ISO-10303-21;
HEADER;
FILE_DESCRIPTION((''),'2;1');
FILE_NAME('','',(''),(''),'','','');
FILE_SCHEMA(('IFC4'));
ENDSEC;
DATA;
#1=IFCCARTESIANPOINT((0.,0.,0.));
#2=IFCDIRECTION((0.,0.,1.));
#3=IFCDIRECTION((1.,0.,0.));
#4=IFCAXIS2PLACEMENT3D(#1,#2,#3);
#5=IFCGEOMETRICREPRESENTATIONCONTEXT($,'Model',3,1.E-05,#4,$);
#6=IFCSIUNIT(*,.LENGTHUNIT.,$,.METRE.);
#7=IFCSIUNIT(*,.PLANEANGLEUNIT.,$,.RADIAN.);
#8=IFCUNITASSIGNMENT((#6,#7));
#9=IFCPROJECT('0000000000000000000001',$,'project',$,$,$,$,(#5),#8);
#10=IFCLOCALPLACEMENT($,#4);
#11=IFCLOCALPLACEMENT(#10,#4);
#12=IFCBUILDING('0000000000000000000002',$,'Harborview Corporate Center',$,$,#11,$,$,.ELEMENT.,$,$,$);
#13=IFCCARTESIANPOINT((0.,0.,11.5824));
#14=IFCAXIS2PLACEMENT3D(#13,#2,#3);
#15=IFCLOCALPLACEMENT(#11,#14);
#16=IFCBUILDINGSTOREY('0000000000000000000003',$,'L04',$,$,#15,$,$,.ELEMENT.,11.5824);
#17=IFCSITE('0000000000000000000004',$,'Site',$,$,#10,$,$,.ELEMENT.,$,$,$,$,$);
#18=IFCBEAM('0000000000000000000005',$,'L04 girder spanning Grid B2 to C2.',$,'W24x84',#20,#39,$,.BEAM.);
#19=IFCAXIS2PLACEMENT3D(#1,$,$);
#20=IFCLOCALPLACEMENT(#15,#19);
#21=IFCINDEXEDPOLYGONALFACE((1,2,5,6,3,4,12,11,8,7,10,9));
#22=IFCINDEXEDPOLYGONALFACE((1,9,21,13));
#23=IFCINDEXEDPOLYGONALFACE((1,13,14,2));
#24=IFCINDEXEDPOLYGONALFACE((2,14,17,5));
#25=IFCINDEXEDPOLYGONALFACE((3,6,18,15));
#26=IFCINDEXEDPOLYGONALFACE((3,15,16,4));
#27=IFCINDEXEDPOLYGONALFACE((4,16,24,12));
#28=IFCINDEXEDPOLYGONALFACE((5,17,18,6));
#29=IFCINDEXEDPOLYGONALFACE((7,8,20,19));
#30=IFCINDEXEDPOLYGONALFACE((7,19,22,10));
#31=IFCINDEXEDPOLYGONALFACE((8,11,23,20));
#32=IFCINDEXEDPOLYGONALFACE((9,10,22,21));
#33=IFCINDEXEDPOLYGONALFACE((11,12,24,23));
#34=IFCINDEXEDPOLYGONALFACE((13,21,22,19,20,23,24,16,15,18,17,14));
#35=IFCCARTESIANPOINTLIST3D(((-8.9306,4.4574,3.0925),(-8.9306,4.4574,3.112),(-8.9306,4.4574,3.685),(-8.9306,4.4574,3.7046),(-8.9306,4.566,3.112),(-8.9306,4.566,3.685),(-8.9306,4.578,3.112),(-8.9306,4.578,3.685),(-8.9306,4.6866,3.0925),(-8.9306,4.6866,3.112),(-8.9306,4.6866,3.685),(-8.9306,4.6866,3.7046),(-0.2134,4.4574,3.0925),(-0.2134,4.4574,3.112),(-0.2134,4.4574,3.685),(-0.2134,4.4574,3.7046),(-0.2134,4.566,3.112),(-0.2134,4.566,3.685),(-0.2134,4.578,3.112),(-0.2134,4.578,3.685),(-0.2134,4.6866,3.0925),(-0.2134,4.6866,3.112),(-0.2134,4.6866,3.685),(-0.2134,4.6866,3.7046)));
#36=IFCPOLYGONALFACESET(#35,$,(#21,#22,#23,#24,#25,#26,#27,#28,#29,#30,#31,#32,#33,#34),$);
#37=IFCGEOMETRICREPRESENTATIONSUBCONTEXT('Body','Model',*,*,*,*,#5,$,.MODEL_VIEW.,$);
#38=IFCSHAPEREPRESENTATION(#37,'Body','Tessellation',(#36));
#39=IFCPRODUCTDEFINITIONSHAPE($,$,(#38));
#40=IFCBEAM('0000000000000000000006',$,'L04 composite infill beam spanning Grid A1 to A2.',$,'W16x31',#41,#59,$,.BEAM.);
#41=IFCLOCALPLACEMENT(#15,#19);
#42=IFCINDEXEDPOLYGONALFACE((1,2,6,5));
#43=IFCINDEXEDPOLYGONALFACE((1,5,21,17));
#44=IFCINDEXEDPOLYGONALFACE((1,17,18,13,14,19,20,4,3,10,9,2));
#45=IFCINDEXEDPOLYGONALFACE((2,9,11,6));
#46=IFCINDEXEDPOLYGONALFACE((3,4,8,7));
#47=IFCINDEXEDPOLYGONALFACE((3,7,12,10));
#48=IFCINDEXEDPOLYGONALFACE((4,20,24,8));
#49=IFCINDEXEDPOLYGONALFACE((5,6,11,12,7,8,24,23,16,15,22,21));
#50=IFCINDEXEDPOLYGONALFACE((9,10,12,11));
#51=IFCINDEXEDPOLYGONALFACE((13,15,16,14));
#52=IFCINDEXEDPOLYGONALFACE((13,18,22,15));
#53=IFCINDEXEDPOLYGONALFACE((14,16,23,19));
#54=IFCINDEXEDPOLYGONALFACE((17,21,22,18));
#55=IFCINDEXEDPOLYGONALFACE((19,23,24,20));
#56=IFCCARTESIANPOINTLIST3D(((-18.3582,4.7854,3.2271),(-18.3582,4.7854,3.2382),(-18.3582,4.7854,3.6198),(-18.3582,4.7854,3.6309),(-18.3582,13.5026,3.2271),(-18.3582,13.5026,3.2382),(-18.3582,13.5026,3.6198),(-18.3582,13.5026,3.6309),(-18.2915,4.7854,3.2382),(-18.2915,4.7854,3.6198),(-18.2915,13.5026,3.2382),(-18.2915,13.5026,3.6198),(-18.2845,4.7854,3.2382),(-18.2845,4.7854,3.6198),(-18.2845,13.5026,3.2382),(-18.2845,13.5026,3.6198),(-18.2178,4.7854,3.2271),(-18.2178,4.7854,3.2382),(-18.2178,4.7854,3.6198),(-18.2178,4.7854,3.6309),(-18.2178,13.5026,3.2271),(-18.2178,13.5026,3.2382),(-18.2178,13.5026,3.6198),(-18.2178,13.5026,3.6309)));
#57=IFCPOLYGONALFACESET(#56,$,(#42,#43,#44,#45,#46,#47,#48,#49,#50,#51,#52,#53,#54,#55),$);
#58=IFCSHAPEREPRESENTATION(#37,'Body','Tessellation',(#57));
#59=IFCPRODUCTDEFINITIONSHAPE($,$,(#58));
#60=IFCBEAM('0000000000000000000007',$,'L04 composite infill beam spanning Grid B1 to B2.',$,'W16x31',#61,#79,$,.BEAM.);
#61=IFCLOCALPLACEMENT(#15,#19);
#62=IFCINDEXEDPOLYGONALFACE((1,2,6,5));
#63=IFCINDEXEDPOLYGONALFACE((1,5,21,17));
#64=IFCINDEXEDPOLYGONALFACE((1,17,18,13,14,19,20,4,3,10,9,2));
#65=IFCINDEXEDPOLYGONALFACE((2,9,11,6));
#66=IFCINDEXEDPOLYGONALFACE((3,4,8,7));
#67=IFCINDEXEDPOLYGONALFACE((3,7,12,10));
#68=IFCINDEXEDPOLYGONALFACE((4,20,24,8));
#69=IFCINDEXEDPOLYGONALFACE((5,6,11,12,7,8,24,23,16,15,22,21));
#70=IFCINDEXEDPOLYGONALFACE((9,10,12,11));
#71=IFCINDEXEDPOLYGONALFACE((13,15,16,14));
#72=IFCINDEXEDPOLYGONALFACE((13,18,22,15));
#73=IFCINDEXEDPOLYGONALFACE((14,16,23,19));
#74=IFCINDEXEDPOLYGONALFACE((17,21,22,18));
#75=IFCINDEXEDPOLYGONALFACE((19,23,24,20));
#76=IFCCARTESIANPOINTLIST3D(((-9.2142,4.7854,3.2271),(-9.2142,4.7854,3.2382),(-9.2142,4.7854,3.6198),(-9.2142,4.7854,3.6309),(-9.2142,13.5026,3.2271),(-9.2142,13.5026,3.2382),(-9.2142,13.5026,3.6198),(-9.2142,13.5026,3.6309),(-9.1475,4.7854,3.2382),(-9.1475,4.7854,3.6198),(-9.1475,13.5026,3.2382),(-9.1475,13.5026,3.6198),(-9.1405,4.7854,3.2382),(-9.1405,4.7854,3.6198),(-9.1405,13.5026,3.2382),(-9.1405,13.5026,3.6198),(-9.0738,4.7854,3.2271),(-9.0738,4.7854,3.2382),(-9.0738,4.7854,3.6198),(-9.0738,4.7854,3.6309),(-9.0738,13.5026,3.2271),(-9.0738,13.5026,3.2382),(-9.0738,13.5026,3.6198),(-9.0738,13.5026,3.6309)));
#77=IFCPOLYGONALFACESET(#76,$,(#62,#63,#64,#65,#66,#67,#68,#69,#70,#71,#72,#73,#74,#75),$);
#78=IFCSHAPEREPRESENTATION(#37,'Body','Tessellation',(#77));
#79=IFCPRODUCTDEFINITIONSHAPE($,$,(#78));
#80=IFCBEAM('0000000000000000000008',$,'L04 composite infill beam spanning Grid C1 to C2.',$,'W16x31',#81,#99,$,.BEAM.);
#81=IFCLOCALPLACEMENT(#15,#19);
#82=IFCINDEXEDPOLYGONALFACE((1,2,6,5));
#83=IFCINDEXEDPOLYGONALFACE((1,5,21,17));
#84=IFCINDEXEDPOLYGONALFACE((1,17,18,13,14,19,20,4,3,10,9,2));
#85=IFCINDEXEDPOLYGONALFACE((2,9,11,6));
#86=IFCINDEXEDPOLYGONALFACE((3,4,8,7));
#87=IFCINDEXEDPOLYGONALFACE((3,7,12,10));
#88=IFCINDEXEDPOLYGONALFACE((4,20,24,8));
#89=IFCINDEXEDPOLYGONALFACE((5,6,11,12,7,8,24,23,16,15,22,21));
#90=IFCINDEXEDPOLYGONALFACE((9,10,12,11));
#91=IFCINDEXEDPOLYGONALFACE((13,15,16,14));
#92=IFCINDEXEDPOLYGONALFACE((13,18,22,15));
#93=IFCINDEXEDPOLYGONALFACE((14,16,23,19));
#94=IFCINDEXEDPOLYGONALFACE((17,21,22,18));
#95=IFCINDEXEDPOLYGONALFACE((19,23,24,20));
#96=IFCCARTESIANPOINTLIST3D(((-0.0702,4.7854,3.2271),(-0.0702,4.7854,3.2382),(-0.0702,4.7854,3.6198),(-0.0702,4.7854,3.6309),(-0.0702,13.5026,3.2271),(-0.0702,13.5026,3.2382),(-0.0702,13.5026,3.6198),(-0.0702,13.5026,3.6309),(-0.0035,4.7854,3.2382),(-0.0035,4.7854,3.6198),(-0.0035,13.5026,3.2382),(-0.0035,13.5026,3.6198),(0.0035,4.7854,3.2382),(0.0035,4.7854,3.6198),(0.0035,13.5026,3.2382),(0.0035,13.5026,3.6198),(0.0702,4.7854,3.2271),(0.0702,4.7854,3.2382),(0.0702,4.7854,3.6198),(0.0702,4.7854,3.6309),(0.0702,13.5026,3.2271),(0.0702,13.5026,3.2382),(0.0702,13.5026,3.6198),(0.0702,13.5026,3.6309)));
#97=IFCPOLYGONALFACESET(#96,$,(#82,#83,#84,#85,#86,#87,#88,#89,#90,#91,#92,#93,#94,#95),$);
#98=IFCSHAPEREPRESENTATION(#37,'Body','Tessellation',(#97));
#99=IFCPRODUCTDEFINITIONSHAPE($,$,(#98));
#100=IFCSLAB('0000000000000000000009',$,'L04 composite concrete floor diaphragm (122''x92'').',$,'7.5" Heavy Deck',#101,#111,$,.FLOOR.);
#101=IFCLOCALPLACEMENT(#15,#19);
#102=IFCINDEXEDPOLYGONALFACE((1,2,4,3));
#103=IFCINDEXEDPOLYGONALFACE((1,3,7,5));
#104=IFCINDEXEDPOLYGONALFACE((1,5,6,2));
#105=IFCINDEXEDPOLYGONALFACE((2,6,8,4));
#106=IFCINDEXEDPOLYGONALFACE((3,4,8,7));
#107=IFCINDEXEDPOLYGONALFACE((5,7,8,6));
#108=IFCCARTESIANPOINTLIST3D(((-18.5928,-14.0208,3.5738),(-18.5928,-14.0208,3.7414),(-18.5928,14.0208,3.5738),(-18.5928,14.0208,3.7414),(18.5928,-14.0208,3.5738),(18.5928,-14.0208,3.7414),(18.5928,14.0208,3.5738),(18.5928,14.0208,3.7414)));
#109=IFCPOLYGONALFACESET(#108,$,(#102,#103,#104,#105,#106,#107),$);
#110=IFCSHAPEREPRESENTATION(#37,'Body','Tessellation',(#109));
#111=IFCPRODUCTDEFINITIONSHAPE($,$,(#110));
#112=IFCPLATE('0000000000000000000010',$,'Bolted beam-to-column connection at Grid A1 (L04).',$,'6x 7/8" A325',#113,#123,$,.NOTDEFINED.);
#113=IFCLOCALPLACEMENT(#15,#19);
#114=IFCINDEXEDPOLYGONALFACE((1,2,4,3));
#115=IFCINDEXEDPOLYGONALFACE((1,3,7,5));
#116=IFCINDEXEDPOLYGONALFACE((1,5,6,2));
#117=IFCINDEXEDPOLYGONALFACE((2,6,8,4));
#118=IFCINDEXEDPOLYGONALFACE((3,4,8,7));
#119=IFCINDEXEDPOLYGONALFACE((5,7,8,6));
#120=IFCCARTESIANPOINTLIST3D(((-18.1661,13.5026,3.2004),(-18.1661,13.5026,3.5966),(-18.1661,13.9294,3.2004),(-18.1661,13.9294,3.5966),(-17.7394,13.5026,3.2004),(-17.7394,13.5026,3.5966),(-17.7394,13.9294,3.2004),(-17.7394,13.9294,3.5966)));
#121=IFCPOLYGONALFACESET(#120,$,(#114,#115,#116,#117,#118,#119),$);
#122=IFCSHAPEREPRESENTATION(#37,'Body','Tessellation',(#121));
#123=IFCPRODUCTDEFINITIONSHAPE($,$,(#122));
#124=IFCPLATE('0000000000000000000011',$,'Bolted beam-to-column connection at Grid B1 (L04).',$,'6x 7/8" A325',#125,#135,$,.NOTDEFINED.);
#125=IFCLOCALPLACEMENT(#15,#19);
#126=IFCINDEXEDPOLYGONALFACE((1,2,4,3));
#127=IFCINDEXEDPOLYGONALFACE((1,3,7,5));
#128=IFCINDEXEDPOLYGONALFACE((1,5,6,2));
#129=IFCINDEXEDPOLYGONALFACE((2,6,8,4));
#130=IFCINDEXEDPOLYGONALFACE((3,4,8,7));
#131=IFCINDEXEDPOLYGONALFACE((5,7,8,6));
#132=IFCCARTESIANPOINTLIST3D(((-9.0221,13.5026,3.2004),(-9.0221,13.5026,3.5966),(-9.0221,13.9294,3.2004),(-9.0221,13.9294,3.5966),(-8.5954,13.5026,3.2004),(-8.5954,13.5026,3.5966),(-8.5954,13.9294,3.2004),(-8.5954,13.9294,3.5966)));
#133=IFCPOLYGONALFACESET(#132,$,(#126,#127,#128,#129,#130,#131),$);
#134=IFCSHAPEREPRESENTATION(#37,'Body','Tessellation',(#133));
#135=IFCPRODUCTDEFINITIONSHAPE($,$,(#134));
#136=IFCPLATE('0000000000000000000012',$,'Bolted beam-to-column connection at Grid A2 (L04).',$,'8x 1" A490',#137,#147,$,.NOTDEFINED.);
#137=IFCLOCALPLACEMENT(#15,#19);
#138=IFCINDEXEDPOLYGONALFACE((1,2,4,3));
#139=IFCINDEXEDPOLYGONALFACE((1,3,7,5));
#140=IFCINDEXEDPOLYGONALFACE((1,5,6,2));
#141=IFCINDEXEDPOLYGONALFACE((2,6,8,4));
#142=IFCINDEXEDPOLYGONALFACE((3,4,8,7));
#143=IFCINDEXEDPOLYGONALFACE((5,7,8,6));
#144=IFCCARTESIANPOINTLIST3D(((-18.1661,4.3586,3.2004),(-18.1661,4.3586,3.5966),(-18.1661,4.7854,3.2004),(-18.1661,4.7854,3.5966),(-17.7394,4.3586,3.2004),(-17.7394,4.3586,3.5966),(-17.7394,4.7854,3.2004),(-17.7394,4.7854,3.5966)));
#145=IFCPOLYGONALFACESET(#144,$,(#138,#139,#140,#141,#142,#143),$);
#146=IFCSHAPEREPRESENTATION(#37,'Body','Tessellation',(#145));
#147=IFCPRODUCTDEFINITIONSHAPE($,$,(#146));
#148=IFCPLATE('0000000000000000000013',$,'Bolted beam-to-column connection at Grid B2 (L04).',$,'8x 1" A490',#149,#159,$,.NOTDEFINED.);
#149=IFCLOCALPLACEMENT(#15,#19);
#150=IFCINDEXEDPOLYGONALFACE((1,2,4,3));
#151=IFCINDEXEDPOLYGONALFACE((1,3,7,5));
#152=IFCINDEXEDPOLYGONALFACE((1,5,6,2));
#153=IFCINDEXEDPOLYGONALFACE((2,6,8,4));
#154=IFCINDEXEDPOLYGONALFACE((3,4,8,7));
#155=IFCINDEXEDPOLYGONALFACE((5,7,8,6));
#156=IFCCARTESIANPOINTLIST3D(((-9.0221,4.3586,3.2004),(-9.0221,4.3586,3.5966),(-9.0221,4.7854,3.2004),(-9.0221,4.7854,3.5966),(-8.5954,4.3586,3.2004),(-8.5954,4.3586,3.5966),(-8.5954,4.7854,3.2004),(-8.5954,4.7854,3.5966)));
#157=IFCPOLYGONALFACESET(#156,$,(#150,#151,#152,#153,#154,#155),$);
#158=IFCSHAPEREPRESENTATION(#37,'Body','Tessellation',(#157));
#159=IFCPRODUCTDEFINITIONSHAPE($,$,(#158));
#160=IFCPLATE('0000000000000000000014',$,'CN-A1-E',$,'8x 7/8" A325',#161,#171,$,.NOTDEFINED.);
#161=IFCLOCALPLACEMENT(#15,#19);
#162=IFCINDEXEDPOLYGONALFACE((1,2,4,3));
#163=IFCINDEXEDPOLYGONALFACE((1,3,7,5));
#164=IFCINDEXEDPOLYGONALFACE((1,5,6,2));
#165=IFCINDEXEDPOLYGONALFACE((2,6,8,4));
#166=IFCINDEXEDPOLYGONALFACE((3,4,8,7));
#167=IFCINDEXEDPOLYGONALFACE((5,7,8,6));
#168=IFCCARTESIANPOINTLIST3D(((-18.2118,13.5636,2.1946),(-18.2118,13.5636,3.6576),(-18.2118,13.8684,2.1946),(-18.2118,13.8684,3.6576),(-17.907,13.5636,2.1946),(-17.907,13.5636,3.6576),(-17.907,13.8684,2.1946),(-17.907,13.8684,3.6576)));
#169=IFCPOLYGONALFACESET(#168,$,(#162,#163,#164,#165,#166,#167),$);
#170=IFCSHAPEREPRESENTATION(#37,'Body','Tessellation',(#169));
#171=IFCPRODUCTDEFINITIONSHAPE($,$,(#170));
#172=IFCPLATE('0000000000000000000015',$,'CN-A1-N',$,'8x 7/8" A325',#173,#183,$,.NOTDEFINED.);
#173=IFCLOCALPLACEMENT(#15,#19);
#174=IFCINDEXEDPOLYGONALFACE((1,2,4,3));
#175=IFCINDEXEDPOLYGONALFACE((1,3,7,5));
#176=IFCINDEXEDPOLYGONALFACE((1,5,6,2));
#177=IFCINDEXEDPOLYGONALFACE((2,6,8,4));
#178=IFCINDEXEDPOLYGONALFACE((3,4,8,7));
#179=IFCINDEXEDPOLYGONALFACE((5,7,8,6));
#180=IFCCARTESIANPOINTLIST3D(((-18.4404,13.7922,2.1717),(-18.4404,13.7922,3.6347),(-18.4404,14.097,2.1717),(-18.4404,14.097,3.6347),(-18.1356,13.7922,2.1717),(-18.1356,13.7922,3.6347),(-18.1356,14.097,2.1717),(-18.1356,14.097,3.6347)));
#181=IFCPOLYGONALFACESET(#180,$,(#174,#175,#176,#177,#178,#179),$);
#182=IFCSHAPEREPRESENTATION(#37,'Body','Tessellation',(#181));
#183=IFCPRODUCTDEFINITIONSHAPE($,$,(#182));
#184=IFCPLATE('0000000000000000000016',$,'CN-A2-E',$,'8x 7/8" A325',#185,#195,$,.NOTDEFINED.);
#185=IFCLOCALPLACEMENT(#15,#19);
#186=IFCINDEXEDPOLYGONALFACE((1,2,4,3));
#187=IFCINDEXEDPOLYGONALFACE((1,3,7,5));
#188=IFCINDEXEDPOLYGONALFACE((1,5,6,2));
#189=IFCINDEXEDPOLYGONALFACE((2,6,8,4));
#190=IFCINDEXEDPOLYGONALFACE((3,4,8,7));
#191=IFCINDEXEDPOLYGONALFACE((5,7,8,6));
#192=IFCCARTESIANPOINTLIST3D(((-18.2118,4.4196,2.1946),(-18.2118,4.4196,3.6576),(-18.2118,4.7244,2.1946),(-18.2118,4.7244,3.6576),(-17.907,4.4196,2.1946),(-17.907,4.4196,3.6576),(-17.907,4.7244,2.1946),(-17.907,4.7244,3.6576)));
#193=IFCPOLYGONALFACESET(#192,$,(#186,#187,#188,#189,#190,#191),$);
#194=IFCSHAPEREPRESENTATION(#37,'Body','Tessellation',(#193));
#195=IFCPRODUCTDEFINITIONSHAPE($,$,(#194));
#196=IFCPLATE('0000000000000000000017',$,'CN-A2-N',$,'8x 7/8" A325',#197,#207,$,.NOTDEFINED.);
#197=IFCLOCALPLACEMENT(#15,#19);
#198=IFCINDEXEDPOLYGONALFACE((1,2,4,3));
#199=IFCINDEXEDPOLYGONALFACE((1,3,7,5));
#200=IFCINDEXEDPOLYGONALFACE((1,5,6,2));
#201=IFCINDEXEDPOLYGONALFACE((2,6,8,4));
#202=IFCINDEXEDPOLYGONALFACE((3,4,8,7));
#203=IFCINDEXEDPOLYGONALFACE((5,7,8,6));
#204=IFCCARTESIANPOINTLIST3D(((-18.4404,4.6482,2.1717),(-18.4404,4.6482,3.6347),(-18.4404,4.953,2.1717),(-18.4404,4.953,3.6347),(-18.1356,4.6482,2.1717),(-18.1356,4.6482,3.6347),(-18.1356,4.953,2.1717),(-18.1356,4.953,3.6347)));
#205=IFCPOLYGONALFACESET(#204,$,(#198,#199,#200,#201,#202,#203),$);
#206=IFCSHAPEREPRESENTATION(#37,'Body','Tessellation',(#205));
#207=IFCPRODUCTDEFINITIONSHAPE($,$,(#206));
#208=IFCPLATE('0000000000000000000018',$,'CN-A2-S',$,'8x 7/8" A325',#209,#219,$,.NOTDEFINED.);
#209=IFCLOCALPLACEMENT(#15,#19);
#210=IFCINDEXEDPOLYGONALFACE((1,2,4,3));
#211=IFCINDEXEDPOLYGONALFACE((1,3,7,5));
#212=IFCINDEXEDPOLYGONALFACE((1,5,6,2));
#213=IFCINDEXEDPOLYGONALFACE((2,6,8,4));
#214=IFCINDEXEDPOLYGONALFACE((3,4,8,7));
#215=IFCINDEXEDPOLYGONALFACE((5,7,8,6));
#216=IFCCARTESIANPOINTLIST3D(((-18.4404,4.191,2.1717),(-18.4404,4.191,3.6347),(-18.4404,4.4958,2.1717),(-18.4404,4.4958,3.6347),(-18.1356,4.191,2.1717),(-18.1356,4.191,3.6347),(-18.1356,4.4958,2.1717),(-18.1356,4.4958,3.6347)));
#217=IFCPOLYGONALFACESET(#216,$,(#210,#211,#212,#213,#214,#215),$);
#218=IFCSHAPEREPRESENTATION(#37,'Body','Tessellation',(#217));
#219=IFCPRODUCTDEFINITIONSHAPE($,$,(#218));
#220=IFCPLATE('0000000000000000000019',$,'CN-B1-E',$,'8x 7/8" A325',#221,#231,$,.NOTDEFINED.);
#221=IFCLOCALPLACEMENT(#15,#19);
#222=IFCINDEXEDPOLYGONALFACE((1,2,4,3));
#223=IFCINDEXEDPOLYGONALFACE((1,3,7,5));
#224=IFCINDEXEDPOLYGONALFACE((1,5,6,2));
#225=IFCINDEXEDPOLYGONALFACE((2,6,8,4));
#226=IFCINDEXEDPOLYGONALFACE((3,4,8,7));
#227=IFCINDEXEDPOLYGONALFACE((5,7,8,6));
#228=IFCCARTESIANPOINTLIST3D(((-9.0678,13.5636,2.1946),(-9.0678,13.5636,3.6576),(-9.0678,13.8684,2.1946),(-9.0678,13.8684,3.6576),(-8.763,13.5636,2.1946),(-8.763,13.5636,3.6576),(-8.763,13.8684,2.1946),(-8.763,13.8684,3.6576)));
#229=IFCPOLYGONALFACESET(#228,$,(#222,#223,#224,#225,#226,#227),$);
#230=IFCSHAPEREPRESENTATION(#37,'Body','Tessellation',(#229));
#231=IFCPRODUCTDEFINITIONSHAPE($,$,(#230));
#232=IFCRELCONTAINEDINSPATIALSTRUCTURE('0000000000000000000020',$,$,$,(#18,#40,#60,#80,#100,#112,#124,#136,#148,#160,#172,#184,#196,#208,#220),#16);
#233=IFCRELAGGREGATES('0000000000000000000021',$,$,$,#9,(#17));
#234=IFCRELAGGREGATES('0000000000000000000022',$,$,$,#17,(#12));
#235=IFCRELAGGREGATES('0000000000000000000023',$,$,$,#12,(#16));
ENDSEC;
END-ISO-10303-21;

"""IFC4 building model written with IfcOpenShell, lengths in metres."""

from ifc_helpers import new_model, si_unit, frame, origin_with_axes, place, context, subcontext, project, spatial, rectangle, i_section, extrude, element, save


model = new_model("IFC4")

# Units and contexts
model_context = context("Model", 3, precision=1e-05, world=origin_with_axes())
body_context = subcontext(model_context, "Body", "Model", "MODEL_VIEW")
ifc_project = project(units=[si_unit("LENGTHUNIT", "METRE"), si_unit("PLANEANGLEUNIT", "RADIAN")], contexts=[model_context])

# Site, building, storey
site_placement = place(None, origin_with_axes())
site = spatial("IfcSite", under=ifc_project, at=site_placement, Name="Site", CompositionType="ELEMENT")
building_placement = place(site_placement, origin_with_axes())
building = spatial("IfcBuilding", under=site, at=building_placement, Name="Harborview Corporate Center", CompositionType="ELEMENT")
storey_placement = place(building_placement, frame((0.0, 0.0, 11.5824), z_axis=(0.0, 0.0, 1.0), x_axis=(1.0, 0.0, 0.0)))
storey = spatial("IfcBuildingStorey", under=building, at=storey_placement, Name="L04", CompositionType="ELEMENT", Elevation=11.5824)

# Beams
beam_1_placement = place(storey_placement, frame((-8.9306, 4.572, 3.3985), z_axis=(1.0, 0.0, 0.0), x_axis=(0.0, 1.0, 0.0)))
element("IfcBeam", 1, at=beam_1_placement, inside=storey, Name="L04 girder spanning Grid B2 to C2.", ObjectType="W24x84", PredefinedType="BEAM", context=body_context, shape_type="SweptSolid", body=[
    extrude(i_section(OverallWidth=0.2291, OverallDepth=0.6121, WebThickness=0.0119, FlangeThickness=0.0196), origin_with_axes(), (0.0, 0.0, 1.0), 8.7173),
])
for number, where, z_axis, x_axis, name in (
    (2, (-18.288, 4.7854, 3.429), (0.0, 1.0, 0.0), (-1.0, 0.0, 0.0), "L04 composite infill beam spanning Grid A1 to A2."),
    (3, (-9.144, 4.7854, 3.429), (0.0, 1.0, 0.0), (-1.0, 0.0, 0.0), "L04 composite infill beam spanning Grid B1 to B2."),
    (4, (0.0, 4.7854, 3.429), (0.0, 1.0, 0.0), (-1.0, 0.0, 0.0), "L04 composite infill beam spanning Grid C1 to C2."),
):
    element("IfcBeam", number, at=place(storey_placement, frame(where, z_axis=z_axis, x_axis=x_axis)), inside=storey, Name=name, ObjectType="W16x31", PredefinedType="BEAM", context=body_context, shape_type="SweptSolid", body=[
        extrude(i_section(OverallWidth=0.1405, OverallDepth=0.4039, WebThickness=0.007, FlangeThickness=0.0112), origin_with_axes(), (0.0, 0.0, 1.0), 8.7173),
    ])

# Slab
slab_placement = place(storey_placement, frame((0.0, 0.0, 3.5738), z_axis=(0.0, 0.0, 1.0), x_axis=(1.0, 0.0, 0.0)))
element("IfcSlab", 5, at=slab_placement, inside=storey, Name="L04 composite concrete floor diaphragm (122'x92').", ObjectType="7.5\" Heavy Deck", PredefinedType="FLOOR", context=body_context, shape_type="SweptSolid", body=[
    extrude(rectangle(XDim=37.1856, YDim=28.0416), origin_with_axes(), (0.0, 0.0, 1.0), 0.1676),
])

# Plates
plate_1_placement = place(storey_placement, frame((-17.9527, 13.716, 3.2004), z_axis=(0.0, 0.0, 1.0), x_axis=(1.0, 0.0, 0.0)))
element("IfcPlate", 6, at=plate_1_placement, inside=storey, Name="Bolted beam-to-column connection at Grid A1 (L04).", ObjectType="6x 7/8\" A325", PredefinedType="NOTDEFINED", context=body_context, shape_type="SweptSolid", body=[
    extrude(rectangle(XDim=0.4267, YDim=0.4267), origin_with_axes(), (0.0, 0.0, 1.0), 0.3962),
])
plate_2_placement = place(storey_placement, frame((-8.8087, 13.716, 3.2004), z_axis=(0.0, 0.0, 1.0), x_axis=(1.0, 0.0, 0.0)))
element("IfcPlate", 7, at=plate_2_placement, inside=storey, Name="Bolted beam-to-column connection at Grid B1 (L04).", ObjectType="6x 7/8\" A325", PredefinedType="NOTDEFINED", context=body_context, shape_type="SweptSolid", body=[
    extrude(rectangle(XDim=0.4267, YDim=0.4267), origin_with_axes(), (0.0, 0.0, 1.0), 0.3962),
])
plate_3_placement = place(storey_placement, frame((-17.9527, 4.572, 3.2004), z_axis=(0.0, 0.0, 1.0), x_axis=(1.0, 0.0, 0.0)))
element("IfcPlate", 8, at=plate_3_placement, inside=storey, Name="Bolted beam-to-column connection at Grid A2 (L04).", ObjectType="8x 1\" A490", PredefinedType="NOTDEFINED", context=body_context, shape_type="SweptSolid", body=[
    extrude(rectangle(XDim=0.4267, YDim=0.4267), origin_with_axes(), (0.0, 0.0, 1.0), 0.3962),
])
plate_4_placement = place(storey_placement, frame((-8.8087, 4.572, 3.2004), z_axis=(0.0, 0.0, 1.0), x_axis=(1.0, 0.0, 0.0)))
element("IfcPlate", 9, at=plate_4_placement, inside=storey, Name="Bolted beam-to-column connection at Grid B2 (L04).", ObjectType="8x 1\" A490", PredefinedType="NOTDEFINED", context=body_context, shape_type="SweptSolid", body=[
    extrude(rectangle(XDim=0.4267, YDim=0.4267), origin_with_axes(), (0.0, 0.0, 1.0), 0.3962),
])
for number, where, z_axis, x_axis, name in (
    (10, (-18.0594, 13.716, 2.1946), (0.0, 0.0, 1.0), (1.0, 0.0, 0.0), "CN-A1-E"),
    (11, (-18.288, 13.9446, 2.1717), (0.0, 0.0, 1.0), (1.0, 0.0, 0.0), "CN-A1-N"),
    (12, (-18.0594, 4.572, 2.1946), (0.0, 0.0, 1.0), (1.0, 0.0, 0.0), "CN-A2-E"),
    (13, (-18.288, 4.8006, 2.1717), (0.0, 0.0, 1.0), (1.0, 0.0, 0.0), "CN-A2-N"),
    (14, (-18.288, 4.3434, 2.1717), (0.0, 0.0, 1.0), (1.0, 0.0, 0.0), "CN-A2-S"),
    (15, (-8.9154, 13.716, 2.1946), (0.0, 0.0, 1.0), (1.0, 0.0, 0.0), "CN-B1-E"),
):
    element("IfcPlate", number, at=place(storey_placement, frame(where, z_axis=z_axis, x_axis=x_axis)), inside=storey, Name=name, ObjectType="8x 7/8\" A325", PredefinedType="NOTDEFINED", context=body_context, shape_type="SweptSolid", body=[
        extrude(rectangle(XDim=0.3048, YDim=0.3048), origin_with_axes(), (0.0, 0.0, 1.0), 1.463),
    ])

save(model, "model.ifc")
